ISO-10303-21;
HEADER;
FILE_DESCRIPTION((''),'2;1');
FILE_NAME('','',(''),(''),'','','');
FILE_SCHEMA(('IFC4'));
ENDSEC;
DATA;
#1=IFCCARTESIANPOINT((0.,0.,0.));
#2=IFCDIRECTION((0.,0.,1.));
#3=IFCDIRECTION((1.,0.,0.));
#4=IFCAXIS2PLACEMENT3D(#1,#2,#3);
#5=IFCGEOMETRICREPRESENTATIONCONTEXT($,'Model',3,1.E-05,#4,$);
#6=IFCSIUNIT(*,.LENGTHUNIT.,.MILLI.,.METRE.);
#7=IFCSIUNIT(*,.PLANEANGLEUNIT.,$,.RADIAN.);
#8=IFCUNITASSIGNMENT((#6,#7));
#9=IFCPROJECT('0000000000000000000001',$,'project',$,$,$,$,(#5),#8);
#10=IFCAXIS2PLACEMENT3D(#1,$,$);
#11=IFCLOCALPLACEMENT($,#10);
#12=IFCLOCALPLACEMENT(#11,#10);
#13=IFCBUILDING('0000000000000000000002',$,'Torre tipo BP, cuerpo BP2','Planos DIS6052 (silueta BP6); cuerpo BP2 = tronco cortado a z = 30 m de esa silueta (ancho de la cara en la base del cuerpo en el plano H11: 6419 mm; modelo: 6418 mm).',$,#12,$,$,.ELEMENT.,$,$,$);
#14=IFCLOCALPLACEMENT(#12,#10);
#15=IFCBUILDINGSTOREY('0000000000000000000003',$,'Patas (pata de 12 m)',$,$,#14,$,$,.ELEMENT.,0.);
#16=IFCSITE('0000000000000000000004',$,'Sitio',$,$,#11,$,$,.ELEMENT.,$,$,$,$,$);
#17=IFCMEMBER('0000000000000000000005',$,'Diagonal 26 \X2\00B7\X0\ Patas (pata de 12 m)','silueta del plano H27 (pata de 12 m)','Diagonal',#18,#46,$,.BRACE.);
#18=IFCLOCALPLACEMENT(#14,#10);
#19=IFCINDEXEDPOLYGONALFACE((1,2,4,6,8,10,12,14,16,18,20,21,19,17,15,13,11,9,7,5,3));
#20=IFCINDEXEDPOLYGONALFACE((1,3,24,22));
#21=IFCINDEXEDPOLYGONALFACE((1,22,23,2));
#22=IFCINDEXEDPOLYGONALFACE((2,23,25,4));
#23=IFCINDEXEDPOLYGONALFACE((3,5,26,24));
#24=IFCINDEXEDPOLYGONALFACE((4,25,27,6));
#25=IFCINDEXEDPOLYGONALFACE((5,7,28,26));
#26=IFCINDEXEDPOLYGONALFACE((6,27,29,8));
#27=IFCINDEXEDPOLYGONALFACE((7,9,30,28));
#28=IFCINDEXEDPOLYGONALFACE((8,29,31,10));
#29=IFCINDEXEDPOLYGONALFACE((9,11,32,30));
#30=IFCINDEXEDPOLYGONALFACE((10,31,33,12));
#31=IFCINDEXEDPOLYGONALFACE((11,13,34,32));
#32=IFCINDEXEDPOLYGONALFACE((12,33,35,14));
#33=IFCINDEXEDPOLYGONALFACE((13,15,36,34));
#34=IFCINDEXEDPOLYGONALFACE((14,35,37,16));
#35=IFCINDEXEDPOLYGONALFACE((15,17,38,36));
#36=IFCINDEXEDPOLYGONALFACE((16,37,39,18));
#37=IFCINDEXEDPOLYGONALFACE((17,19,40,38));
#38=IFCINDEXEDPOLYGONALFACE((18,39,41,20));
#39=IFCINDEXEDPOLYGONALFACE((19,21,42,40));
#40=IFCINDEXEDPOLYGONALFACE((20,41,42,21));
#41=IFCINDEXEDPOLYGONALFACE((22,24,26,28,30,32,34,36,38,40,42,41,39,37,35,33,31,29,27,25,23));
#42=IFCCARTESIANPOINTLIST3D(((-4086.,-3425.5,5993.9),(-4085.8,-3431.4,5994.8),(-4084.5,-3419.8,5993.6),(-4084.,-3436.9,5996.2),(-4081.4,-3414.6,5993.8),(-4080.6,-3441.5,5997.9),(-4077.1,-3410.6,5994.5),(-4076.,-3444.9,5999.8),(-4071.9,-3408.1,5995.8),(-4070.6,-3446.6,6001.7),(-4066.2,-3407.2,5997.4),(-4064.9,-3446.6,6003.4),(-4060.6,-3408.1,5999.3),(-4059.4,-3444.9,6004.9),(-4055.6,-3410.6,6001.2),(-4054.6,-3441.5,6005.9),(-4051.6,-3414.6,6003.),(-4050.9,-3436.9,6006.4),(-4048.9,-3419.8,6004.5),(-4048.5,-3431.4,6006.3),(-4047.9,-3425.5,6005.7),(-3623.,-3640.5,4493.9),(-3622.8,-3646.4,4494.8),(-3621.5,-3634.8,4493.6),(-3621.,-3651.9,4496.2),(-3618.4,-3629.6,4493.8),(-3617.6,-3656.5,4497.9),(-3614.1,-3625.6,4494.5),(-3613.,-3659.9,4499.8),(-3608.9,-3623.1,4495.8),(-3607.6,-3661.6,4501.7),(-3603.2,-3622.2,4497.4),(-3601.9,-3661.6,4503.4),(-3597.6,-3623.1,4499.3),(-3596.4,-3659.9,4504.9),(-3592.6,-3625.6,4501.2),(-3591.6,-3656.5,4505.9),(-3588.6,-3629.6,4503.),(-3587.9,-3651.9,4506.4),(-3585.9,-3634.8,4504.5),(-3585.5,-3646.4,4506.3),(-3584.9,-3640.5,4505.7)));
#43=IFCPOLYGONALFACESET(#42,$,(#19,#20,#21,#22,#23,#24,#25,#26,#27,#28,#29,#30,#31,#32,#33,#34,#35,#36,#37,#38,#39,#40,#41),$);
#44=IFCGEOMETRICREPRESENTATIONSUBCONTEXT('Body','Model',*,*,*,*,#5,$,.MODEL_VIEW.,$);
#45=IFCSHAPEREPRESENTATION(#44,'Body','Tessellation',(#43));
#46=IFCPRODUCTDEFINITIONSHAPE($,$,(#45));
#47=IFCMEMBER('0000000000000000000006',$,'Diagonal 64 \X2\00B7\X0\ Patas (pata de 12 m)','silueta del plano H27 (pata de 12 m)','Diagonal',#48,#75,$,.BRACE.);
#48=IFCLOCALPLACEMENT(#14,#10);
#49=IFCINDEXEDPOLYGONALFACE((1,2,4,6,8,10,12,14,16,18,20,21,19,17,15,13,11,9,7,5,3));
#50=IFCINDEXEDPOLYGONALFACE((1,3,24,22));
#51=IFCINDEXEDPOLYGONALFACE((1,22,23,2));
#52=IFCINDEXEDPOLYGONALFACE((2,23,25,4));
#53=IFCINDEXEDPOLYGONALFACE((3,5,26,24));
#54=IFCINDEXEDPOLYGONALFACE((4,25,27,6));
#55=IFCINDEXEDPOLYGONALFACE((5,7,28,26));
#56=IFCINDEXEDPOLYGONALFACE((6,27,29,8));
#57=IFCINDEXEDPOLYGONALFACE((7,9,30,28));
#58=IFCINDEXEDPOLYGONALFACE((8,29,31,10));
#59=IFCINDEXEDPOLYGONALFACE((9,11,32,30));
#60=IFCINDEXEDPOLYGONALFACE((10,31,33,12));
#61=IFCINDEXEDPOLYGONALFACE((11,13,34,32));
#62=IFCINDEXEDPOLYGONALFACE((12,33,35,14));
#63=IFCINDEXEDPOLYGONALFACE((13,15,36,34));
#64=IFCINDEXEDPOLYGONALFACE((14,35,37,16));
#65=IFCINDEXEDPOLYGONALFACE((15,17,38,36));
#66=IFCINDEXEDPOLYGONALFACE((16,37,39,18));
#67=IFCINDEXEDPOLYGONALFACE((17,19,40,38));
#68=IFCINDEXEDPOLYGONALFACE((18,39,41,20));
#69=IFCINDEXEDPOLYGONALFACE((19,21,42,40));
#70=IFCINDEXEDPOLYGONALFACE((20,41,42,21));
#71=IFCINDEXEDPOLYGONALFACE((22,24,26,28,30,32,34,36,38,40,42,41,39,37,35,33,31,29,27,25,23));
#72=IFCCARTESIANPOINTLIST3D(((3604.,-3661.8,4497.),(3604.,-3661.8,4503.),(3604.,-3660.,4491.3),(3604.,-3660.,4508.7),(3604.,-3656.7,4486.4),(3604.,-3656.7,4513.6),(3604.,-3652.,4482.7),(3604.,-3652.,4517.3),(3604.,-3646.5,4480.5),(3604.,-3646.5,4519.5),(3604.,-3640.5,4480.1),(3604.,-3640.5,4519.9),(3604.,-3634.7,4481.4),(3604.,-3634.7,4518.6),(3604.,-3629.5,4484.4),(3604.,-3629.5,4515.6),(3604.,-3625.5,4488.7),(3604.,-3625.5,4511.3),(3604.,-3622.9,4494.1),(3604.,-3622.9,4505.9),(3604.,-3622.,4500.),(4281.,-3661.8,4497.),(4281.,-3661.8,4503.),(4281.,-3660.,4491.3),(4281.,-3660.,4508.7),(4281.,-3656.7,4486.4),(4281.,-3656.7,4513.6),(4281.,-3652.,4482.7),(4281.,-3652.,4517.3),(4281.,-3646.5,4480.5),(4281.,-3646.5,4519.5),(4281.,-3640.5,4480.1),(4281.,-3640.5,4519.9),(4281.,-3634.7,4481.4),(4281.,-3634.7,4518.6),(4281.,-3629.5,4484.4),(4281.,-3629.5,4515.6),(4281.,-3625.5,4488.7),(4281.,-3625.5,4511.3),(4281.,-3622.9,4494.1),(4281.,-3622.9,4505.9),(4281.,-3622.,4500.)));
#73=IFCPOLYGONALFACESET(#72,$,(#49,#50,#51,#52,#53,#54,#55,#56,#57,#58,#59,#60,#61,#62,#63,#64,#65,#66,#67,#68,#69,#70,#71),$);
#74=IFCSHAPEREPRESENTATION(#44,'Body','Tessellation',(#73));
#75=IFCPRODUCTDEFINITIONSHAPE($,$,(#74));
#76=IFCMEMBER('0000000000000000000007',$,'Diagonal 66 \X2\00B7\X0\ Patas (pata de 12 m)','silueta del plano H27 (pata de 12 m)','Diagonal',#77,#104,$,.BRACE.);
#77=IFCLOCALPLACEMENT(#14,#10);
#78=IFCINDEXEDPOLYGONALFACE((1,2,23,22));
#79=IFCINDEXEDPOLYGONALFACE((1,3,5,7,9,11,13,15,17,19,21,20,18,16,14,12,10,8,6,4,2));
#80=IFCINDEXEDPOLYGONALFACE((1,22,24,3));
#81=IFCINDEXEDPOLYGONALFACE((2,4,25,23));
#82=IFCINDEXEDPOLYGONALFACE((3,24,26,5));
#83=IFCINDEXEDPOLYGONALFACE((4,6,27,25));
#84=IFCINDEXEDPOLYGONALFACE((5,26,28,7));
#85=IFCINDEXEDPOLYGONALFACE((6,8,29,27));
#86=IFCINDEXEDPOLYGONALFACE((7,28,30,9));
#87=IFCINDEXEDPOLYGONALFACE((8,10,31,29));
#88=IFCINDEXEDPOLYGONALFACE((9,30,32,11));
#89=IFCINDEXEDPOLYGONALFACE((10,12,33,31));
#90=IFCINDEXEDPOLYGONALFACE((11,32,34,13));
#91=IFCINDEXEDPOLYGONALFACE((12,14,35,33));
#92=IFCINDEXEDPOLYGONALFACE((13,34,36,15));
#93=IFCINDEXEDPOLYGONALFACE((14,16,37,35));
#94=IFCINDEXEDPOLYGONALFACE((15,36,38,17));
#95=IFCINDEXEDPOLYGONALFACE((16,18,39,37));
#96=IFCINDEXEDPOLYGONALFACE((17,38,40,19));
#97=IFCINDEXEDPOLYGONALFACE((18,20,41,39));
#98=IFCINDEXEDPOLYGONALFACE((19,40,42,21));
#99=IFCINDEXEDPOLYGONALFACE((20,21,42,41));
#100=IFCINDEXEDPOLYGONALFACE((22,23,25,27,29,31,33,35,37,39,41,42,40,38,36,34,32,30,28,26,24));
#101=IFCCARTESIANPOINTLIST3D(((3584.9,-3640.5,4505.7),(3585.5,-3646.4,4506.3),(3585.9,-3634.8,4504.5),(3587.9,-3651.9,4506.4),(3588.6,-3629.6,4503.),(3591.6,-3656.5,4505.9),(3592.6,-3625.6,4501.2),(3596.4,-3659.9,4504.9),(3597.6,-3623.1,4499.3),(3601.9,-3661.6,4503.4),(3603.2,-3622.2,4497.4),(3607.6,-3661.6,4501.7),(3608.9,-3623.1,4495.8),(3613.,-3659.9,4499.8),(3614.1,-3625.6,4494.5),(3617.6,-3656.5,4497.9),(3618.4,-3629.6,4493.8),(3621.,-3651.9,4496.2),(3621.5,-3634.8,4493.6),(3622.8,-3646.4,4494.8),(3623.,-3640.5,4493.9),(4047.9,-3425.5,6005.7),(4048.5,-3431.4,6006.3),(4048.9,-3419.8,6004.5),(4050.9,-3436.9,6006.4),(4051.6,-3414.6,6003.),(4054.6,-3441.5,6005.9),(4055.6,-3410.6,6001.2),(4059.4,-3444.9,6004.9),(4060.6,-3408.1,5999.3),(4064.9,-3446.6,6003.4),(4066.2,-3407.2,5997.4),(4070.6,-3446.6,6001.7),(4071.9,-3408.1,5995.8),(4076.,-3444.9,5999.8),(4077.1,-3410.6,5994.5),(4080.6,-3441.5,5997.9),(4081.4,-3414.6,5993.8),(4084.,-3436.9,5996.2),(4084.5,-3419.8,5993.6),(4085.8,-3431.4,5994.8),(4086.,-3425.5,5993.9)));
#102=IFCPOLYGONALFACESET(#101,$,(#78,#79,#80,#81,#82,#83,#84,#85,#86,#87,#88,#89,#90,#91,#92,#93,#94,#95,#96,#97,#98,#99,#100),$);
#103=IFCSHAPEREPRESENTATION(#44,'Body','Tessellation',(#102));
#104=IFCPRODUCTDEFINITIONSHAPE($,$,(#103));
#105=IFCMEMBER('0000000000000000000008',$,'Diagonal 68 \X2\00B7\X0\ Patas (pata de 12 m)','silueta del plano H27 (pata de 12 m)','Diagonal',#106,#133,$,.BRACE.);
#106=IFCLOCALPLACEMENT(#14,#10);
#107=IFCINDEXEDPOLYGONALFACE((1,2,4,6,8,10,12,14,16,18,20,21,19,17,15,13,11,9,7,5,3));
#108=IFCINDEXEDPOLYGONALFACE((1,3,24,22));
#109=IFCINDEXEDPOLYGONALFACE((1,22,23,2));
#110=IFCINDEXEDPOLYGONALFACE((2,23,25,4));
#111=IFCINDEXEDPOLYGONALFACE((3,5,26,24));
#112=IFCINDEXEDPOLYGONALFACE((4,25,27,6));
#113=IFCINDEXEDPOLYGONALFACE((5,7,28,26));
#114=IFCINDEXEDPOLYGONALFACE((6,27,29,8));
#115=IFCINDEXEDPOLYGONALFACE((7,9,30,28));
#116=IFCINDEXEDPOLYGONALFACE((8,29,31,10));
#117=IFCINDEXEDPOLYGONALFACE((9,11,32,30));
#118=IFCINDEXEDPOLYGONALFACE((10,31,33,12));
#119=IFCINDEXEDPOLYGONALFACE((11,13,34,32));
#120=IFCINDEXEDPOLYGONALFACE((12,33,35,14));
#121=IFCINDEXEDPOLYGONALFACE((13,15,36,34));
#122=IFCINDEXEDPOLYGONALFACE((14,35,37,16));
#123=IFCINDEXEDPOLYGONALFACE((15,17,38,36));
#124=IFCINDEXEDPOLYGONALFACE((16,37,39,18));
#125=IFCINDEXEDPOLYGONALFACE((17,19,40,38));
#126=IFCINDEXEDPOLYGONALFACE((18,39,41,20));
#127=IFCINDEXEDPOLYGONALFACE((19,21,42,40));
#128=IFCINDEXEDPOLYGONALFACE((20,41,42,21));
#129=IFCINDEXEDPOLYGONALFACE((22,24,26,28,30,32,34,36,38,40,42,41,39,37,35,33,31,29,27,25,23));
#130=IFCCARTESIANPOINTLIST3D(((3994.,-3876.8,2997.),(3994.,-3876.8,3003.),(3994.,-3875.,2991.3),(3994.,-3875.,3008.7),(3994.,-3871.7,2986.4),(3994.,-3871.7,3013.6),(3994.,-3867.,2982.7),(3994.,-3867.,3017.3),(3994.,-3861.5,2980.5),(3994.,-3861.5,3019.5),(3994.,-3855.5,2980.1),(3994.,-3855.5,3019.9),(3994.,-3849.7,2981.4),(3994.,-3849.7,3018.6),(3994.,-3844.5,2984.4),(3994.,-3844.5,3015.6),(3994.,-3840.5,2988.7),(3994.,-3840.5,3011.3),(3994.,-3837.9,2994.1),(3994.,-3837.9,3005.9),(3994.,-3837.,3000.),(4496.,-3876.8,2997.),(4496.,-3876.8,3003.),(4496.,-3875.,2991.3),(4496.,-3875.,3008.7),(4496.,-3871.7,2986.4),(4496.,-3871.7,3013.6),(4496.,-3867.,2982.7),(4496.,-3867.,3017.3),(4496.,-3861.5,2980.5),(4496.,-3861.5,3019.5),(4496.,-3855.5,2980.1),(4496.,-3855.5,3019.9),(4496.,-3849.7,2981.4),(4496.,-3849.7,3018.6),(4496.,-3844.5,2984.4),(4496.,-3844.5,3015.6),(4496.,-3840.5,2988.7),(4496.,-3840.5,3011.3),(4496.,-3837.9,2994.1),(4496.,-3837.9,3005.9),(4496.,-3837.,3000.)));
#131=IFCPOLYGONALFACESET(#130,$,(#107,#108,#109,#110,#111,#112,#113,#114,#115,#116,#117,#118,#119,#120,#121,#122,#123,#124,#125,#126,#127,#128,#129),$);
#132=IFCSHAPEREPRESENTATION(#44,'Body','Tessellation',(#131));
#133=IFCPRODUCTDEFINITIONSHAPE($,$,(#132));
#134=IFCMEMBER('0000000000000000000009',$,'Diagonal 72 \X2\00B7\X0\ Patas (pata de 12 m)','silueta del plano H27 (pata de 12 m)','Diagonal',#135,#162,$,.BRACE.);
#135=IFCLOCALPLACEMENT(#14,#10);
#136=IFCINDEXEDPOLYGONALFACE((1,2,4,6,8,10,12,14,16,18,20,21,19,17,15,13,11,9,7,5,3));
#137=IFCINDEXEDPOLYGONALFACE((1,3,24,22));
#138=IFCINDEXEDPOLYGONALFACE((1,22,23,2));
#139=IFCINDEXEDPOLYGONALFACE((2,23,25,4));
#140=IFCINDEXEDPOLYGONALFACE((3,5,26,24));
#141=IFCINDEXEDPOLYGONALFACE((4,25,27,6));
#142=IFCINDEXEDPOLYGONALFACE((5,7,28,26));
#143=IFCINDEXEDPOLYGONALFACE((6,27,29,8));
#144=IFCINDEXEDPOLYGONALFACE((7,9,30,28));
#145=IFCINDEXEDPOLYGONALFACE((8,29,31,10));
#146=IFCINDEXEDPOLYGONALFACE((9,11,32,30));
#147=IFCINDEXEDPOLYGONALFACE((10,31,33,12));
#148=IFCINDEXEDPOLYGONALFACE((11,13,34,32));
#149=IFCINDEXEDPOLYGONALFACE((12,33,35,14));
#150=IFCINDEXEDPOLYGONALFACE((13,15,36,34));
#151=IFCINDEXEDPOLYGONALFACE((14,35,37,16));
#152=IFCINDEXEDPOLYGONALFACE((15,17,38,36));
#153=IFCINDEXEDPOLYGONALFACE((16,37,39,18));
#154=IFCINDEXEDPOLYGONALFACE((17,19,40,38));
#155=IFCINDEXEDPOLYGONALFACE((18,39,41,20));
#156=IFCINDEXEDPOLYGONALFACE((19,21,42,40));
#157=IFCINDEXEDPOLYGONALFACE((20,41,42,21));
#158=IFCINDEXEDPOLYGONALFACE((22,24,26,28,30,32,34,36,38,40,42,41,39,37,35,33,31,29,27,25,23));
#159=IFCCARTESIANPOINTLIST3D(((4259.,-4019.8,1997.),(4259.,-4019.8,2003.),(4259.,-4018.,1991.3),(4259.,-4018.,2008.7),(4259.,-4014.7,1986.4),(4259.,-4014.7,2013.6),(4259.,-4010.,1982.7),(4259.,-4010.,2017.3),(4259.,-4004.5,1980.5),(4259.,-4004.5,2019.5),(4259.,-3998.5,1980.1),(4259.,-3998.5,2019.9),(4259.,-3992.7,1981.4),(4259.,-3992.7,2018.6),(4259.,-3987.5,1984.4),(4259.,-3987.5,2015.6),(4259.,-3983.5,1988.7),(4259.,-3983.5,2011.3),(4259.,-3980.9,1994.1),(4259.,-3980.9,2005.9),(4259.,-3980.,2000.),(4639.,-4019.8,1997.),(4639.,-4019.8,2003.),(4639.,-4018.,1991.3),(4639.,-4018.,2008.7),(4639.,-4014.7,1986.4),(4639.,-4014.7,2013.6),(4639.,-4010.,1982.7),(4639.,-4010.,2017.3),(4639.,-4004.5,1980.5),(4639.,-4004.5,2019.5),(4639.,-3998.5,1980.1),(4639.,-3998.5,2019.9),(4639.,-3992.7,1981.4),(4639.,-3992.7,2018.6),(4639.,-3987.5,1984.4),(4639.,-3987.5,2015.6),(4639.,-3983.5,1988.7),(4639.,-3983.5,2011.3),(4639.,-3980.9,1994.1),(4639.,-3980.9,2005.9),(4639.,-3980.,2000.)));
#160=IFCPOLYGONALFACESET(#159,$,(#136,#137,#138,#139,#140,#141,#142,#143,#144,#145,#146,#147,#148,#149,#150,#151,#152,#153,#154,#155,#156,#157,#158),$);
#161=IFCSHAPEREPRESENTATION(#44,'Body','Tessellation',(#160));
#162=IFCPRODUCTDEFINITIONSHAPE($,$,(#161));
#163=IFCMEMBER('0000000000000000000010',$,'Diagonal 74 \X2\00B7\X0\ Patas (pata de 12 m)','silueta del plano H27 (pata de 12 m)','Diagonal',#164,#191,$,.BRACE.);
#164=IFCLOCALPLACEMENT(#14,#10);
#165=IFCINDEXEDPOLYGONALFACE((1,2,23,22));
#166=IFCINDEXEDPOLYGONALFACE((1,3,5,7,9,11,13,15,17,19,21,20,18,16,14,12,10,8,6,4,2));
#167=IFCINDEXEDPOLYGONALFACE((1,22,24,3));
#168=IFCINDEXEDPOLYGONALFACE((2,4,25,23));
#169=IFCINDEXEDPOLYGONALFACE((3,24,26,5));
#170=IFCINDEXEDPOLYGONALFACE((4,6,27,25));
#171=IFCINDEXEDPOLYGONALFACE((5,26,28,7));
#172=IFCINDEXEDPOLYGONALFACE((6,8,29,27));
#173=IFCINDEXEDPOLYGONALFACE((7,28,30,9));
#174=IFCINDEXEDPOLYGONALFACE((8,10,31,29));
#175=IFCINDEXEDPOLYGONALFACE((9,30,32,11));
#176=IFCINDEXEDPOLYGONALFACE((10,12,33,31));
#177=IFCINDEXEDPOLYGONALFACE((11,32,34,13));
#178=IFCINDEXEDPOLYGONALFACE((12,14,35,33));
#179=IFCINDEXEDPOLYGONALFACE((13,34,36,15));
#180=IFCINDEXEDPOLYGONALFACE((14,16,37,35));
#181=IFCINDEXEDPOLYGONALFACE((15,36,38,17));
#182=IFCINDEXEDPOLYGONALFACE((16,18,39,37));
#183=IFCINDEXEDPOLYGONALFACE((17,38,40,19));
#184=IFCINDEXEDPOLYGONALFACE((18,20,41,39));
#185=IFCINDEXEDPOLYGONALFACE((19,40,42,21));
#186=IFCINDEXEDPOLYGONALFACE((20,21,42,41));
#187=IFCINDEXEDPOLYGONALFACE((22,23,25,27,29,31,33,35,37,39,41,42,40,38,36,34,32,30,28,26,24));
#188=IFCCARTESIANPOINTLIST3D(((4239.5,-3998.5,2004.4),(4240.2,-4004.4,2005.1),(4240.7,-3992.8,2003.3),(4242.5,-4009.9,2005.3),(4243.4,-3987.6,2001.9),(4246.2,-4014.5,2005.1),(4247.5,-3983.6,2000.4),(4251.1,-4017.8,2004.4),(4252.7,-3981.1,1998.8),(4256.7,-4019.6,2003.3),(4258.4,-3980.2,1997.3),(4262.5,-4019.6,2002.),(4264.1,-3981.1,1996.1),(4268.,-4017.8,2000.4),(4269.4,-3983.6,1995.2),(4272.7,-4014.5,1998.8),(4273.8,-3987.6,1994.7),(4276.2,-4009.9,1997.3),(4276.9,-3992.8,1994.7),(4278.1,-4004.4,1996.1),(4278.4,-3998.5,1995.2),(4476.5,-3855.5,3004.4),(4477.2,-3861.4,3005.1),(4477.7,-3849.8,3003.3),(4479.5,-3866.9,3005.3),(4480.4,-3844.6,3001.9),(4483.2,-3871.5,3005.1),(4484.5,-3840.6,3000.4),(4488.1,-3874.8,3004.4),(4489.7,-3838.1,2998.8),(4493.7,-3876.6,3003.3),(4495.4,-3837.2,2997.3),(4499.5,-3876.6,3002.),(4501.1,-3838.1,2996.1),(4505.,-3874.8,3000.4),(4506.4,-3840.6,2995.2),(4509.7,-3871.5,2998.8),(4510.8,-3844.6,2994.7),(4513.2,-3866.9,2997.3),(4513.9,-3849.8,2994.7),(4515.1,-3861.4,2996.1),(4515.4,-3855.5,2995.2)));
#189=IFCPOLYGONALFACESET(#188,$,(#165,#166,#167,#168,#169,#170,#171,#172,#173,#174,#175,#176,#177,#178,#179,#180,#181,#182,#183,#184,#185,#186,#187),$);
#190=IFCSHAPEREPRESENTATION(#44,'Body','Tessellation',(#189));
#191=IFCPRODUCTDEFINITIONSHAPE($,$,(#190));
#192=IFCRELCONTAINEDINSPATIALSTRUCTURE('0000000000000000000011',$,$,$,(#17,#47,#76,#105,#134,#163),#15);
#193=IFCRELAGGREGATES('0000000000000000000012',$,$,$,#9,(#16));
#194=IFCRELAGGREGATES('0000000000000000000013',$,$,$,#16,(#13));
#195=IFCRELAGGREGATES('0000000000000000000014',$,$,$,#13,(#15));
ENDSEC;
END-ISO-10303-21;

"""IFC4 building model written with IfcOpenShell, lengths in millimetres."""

from ifc_helpers import new_model, si_unit, frame, origin, origin_with_axes, place, context, subcontext, project, spatial, circle, extrude, element, save


model = new_model("IFC4")

# Units and contexts
model_context = context("Model", 3, precision=1e-05, world=origin_with_axes())
body_context = subcontext(model_context, "Body", "Model", "MODEL_VIEW")
ifc_project = project(units=[si_unit("LENGTHUNIT", "METRE", prefix="MILLI"), si_unit("PLANEANGLEUNIT", "RADIAN")], contexts=[model_context])

# Site, building, storey
site_placement = place(None, origin())
site = spatial("IfcSite", under=ifc_project, at=site_placement, Name="Sitio", CompositionType="ELEMENT")
building_placement = place(site_placement, origin())
building = spatial("IfcBuilding", under=site, at=building_placement, Name="Torre tipo BP, cuerpo BP2", Description="Planos DIS6052 (silueta BP6); cuerpo BP2 = tronco cortado a z = 30 m de esa silueta (ancho de la cara en la base del cuerpo en el plano H11: 6419 mm; modelo: 6418 mm).", CompositionType="ELEMENT")
storey_placement = place(building_placement, origin())
storey = spatial("IfcBuildingStorey", under=building, at=storey_placement, Name="Patas (pata de 12 m)", CompositionType="ELEMENT", Elevation=0.0)

# Members
member_1_placement = place(storey_placement, frame((-3604.0, -3642.0, 4500.0), z_axis=(-0.292208, 0.135691, 0.94668), x_axis=(0.04002, 0.990751, -0.129655)))
element("IfcMember", 1, at=member_1_placement, inside=storey, Name="Diagonal 26 · Patas (pata de 12 m)", Description="silueta del plano H27 (pata de 12 m)", ObjectType="Diagonal", PredefinedType="BRACE", context=body_context, shape_type="SweptSolid", body=[
    extrude(circle(Radius=20.0), None, (0.0, 0.0, 1.0), 1584.5),
])
member_2_placement = place(storey_placement, frame((4281.0, -3642.0, 4500.0), z_axis=(-1.0, 0.0, 0.0), x_axis=(0.0, 1.0, 0.0)))
element("IfcMember", 2, at=member_2_placement, inside=storey, Name="Diagonal 64 · Patas (pata de 12 m)", Description="silueta del plano H27 (pata de 12 m)", ObjectType="Diagonal", PredefinedType="BRACE", context=body_context, shape_type="SweptSolid", body=[
    extrude(circle(Radius=20.0), None, (0.0, 0.0, 1.0), 677.0),
])
member_3_placement = place(storey_placement, frame((3604.0, -3642.0, 4500.0), z_axis=(0.292208, 0.135691, 0.94668), x_axis=(-0.04002, 0.990751, -0.129655)))
element("IfcMember", 3, at=member_3_placement, inside=storey, Name="Diagonal 66 · Patas (pata de 12 m)", Description="silueta del plano H27 (pata de 12 m)", ObjectType="Diagonal", PredefinedType="BRACE", context=body_context, shape_type="SweptSolid", body=[
    extrude(circle(Radius=20.0), None, (0.0, 0.0, 1.0), 1584.5),
])
member_4_placement = place(storey_placement, frame((4496.0, -3857.0, 3000.0), z_axis=(-1.0, 0.0, 0.0), x_axis=(0.0, 1.0, 0.0)))
element("IfcMember", 4, at=member_4_placement, inside=storey, Name="Diagonal 68 · Patas (pata de 12 m)", Description="silueta del plano H27 (pata de 12 m)", ObjectType="Diagonal", PredefinedType="BRACE", context=body_context, shape_type="SweptSolid", body=[
    extrude(circle(Radius=20.0), None, (0.0, 0.0, 1.0), 502.0),
])
member_5_placement = place(storey_placement, frame((4639.0, -4000.0, 2000.0), z_axis=(-1.0, 0.0, 0.0), x_axis=(0.0, 1.0, 0.0)))
element("IfcMember", 5, at=member_5_placement, inside=storey, Name="Diagonal 72 · Patas (pata de 12 m)", Description="silueta del plano H27 (pata de 12 m)", ObjectType="Diagonal", PredefinedType="BRACE", context=body_context, shape_type="SweptSolid", body=[
    extrude(circle(Radius=20.0), None, (0.0, 0.0, 1.0), 380.0),
])
member_6_placement = place(storey_placement, frame((4259.0, -4000.0, 2000.0), z_axis=(0.228411, 0.137818, 0.963761), x_axis=(-0.031782, 0.990458, -0.134103)))
element("IfcMember", 6, at=member_6_placement, inside=storey, Name="Diagonal 74 · Patas (pata de 12 m)", Description="silueta del plano H27 (pata de 12 m)", ObjectType="Diagonal", PredefinedType="BRACE", context=body_context, shape_type="SweptSolid", body=[
    extrude(circle(Radius=20.0), None, (0.0, 0.0, 1.0), 1037.6),
])

save(model, "model.ifc")
